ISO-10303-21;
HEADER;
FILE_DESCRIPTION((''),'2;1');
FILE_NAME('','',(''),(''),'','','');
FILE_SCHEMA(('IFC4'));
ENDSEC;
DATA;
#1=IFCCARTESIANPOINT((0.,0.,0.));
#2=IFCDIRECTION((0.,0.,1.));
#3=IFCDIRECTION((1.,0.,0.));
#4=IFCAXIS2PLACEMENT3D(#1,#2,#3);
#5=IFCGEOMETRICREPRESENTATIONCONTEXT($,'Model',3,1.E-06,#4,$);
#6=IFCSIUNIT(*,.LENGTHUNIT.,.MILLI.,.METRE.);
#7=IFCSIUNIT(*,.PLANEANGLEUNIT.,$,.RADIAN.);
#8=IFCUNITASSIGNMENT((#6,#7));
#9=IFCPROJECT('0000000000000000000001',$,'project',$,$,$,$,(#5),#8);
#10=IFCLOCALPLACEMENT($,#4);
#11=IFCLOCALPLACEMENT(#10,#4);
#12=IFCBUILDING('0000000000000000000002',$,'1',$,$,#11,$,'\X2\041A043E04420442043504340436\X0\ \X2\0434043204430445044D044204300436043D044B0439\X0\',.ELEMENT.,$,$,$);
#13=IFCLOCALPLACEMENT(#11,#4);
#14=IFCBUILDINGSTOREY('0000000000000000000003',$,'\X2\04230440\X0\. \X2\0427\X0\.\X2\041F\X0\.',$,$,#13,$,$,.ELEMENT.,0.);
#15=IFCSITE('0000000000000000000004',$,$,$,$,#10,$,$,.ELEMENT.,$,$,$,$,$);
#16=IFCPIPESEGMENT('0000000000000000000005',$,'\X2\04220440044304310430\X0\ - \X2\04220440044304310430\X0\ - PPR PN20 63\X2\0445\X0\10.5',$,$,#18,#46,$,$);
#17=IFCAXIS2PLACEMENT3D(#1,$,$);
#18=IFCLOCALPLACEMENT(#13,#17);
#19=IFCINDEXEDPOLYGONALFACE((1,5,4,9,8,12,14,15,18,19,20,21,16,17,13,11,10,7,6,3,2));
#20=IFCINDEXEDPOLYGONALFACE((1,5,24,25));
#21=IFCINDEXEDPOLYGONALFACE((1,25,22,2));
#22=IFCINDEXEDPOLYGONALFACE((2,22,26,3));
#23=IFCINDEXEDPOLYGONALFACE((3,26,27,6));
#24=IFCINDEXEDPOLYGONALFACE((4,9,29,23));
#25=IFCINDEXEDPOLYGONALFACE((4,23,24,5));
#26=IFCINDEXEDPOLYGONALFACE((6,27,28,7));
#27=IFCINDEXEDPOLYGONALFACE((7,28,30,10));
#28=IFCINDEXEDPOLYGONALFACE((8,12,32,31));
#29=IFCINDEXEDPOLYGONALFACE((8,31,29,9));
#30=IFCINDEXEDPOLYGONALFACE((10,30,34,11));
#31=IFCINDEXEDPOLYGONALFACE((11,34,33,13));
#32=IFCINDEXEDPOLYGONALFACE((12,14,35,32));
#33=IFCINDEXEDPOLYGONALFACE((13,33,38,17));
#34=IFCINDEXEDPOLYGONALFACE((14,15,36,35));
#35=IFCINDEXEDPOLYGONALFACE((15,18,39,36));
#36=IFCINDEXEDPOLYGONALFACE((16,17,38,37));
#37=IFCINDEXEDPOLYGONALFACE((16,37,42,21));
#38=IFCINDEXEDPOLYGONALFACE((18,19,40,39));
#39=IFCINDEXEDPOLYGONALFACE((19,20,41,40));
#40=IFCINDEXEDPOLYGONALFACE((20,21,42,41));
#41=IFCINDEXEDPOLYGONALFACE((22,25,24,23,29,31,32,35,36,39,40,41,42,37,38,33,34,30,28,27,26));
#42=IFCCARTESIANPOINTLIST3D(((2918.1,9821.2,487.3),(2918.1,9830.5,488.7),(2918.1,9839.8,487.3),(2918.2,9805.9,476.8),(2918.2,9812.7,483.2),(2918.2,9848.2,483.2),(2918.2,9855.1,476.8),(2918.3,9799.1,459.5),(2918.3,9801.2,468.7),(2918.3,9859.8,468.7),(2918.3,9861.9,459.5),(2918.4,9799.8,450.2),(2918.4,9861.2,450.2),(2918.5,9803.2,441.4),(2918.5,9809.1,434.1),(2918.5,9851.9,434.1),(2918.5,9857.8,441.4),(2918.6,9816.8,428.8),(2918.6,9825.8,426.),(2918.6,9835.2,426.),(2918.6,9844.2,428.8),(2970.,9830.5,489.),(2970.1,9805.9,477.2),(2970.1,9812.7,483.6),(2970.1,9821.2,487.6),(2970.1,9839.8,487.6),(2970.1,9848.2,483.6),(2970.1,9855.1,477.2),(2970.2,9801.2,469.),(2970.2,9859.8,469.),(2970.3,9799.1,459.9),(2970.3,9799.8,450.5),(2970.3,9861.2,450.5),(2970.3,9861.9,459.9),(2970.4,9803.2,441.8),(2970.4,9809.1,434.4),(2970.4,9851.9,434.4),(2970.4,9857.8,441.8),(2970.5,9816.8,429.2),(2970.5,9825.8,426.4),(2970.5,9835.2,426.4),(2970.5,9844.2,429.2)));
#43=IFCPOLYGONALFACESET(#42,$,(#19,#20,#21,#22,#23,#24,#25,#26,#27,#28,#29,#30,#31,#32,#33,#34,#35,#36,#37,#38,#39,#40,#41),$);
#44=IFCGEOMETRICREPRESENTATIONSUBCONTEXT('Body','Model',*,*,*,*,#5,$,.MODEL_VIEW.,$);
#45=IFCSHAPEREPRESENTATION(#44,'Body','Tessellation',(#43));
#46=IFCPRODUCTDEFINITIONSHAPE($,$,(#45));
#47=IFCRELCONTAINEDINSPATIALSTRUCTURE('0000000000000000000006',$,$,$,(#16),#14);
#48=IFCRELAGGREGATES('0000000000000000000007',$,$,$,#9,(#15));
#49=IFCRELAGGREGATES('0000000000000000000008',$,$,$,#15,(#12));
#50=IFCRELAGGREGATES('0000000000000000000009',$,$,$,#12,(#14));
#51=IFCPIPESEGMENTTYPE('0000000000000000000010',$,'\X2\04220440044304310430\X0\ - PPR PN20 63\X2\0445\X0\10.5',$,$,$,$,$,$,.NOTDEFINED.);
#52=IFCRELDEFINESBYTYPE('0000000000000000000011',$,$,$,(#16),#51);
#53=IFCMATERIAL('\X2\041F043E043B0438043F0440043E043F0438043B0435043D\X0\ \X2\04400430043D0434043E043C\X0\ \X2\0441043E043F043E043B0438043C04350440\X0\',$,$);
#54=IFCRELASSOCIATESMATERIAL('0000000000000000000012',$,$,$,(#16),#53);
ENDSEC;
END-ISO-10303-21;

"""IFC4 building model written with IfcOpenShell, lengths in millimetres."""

from ifc_helpers import new_model, entity, si_unit, frame, origin_with_axes, place, context, subcontext, project, spatial, source, transform, mapped, material, type_object, element, save


model = new_model("IFC4")

# Units and contexts
model_context = context("Model", 3, precision=1e-06, world=origin_with_axes())
body_context = subcontext(model_context, "Body", "Model", "MODEL_VIEW")
ifc_project = project(units=[si_unit("LENGTHUNIT", "METRE", prefix="MILLI"), si_unit("PLANEANGLEUNIT", "RADIAN")], contexts=[model_context])

# Site, building, storey
site_placement = place(None, origin_with_axes())
site = spatial("IfcSite", under=ifc_project, at=site_placement, CompositionType="ELEMENT")
building_placement = place(site_placement, origin_with_axes())
building = spatial("IfcBuilding", under=site, at=building_placement, Name="1", LongName="Коттедж двухэтажный", CompositionType="ELEMENT")
storey_placement = place(building_placement, origin_with_axes())
storey = spatial("IfcBuildingStorey", under=building, at=storey_placement, Name="Ур. Ч.П.", CompositionType="ELEMENT", Elevation=0.0)

# Pipe segment
ifc_material_1 = material(Name="Полипропилен рандом сополимер")
pipe_segment_type_1 = type_object("IfcPipeSegmentType", Name="Труба - PPR PN20 63х10.5", PredefinedType="NOTDEFINED")
shared_shape_1 = source(origin_with_axes(), body_context, "Body", "AdvancedSweptSolid", [
    entity("IfcSweptDiskSolid", entity("IfcIndexedPolyCurve", entity("IfcCartesianPointList3D", [[0.0, 0.0, 0.0], [51.9, 0.0, 0.4]]), [entity("IfcLineIndex", [1, 2])]), 31.5),
])
pipe_segment_1_placement = place(storey_placement, frame((2918.4, 9830.5, 457.2), z_axis=(0.0, 0.0, 1.0), x_axis=(1.0, 0.0, 0.0)))
element("IfcPipeSegment", 1, at=pipe_segment_1_placement, inside=storey, type_object=pipe_segment_type_1, material=ifc_material_1, Name="Труба - Труба - PPR PN20 63х10.5", context=body_context, shape_type="MappedRepresentation", body=[
    mapped(shared_shape_1, transform((0.0, 0.0, 0.0), x_axis=(1.0, 0.0, 0.0), y_axis=(0.0, 1.0, 0.0), z_axis=(0.0, 0.0, 1.0), scale=1.0)),
])

save(model, "model.ifc")
